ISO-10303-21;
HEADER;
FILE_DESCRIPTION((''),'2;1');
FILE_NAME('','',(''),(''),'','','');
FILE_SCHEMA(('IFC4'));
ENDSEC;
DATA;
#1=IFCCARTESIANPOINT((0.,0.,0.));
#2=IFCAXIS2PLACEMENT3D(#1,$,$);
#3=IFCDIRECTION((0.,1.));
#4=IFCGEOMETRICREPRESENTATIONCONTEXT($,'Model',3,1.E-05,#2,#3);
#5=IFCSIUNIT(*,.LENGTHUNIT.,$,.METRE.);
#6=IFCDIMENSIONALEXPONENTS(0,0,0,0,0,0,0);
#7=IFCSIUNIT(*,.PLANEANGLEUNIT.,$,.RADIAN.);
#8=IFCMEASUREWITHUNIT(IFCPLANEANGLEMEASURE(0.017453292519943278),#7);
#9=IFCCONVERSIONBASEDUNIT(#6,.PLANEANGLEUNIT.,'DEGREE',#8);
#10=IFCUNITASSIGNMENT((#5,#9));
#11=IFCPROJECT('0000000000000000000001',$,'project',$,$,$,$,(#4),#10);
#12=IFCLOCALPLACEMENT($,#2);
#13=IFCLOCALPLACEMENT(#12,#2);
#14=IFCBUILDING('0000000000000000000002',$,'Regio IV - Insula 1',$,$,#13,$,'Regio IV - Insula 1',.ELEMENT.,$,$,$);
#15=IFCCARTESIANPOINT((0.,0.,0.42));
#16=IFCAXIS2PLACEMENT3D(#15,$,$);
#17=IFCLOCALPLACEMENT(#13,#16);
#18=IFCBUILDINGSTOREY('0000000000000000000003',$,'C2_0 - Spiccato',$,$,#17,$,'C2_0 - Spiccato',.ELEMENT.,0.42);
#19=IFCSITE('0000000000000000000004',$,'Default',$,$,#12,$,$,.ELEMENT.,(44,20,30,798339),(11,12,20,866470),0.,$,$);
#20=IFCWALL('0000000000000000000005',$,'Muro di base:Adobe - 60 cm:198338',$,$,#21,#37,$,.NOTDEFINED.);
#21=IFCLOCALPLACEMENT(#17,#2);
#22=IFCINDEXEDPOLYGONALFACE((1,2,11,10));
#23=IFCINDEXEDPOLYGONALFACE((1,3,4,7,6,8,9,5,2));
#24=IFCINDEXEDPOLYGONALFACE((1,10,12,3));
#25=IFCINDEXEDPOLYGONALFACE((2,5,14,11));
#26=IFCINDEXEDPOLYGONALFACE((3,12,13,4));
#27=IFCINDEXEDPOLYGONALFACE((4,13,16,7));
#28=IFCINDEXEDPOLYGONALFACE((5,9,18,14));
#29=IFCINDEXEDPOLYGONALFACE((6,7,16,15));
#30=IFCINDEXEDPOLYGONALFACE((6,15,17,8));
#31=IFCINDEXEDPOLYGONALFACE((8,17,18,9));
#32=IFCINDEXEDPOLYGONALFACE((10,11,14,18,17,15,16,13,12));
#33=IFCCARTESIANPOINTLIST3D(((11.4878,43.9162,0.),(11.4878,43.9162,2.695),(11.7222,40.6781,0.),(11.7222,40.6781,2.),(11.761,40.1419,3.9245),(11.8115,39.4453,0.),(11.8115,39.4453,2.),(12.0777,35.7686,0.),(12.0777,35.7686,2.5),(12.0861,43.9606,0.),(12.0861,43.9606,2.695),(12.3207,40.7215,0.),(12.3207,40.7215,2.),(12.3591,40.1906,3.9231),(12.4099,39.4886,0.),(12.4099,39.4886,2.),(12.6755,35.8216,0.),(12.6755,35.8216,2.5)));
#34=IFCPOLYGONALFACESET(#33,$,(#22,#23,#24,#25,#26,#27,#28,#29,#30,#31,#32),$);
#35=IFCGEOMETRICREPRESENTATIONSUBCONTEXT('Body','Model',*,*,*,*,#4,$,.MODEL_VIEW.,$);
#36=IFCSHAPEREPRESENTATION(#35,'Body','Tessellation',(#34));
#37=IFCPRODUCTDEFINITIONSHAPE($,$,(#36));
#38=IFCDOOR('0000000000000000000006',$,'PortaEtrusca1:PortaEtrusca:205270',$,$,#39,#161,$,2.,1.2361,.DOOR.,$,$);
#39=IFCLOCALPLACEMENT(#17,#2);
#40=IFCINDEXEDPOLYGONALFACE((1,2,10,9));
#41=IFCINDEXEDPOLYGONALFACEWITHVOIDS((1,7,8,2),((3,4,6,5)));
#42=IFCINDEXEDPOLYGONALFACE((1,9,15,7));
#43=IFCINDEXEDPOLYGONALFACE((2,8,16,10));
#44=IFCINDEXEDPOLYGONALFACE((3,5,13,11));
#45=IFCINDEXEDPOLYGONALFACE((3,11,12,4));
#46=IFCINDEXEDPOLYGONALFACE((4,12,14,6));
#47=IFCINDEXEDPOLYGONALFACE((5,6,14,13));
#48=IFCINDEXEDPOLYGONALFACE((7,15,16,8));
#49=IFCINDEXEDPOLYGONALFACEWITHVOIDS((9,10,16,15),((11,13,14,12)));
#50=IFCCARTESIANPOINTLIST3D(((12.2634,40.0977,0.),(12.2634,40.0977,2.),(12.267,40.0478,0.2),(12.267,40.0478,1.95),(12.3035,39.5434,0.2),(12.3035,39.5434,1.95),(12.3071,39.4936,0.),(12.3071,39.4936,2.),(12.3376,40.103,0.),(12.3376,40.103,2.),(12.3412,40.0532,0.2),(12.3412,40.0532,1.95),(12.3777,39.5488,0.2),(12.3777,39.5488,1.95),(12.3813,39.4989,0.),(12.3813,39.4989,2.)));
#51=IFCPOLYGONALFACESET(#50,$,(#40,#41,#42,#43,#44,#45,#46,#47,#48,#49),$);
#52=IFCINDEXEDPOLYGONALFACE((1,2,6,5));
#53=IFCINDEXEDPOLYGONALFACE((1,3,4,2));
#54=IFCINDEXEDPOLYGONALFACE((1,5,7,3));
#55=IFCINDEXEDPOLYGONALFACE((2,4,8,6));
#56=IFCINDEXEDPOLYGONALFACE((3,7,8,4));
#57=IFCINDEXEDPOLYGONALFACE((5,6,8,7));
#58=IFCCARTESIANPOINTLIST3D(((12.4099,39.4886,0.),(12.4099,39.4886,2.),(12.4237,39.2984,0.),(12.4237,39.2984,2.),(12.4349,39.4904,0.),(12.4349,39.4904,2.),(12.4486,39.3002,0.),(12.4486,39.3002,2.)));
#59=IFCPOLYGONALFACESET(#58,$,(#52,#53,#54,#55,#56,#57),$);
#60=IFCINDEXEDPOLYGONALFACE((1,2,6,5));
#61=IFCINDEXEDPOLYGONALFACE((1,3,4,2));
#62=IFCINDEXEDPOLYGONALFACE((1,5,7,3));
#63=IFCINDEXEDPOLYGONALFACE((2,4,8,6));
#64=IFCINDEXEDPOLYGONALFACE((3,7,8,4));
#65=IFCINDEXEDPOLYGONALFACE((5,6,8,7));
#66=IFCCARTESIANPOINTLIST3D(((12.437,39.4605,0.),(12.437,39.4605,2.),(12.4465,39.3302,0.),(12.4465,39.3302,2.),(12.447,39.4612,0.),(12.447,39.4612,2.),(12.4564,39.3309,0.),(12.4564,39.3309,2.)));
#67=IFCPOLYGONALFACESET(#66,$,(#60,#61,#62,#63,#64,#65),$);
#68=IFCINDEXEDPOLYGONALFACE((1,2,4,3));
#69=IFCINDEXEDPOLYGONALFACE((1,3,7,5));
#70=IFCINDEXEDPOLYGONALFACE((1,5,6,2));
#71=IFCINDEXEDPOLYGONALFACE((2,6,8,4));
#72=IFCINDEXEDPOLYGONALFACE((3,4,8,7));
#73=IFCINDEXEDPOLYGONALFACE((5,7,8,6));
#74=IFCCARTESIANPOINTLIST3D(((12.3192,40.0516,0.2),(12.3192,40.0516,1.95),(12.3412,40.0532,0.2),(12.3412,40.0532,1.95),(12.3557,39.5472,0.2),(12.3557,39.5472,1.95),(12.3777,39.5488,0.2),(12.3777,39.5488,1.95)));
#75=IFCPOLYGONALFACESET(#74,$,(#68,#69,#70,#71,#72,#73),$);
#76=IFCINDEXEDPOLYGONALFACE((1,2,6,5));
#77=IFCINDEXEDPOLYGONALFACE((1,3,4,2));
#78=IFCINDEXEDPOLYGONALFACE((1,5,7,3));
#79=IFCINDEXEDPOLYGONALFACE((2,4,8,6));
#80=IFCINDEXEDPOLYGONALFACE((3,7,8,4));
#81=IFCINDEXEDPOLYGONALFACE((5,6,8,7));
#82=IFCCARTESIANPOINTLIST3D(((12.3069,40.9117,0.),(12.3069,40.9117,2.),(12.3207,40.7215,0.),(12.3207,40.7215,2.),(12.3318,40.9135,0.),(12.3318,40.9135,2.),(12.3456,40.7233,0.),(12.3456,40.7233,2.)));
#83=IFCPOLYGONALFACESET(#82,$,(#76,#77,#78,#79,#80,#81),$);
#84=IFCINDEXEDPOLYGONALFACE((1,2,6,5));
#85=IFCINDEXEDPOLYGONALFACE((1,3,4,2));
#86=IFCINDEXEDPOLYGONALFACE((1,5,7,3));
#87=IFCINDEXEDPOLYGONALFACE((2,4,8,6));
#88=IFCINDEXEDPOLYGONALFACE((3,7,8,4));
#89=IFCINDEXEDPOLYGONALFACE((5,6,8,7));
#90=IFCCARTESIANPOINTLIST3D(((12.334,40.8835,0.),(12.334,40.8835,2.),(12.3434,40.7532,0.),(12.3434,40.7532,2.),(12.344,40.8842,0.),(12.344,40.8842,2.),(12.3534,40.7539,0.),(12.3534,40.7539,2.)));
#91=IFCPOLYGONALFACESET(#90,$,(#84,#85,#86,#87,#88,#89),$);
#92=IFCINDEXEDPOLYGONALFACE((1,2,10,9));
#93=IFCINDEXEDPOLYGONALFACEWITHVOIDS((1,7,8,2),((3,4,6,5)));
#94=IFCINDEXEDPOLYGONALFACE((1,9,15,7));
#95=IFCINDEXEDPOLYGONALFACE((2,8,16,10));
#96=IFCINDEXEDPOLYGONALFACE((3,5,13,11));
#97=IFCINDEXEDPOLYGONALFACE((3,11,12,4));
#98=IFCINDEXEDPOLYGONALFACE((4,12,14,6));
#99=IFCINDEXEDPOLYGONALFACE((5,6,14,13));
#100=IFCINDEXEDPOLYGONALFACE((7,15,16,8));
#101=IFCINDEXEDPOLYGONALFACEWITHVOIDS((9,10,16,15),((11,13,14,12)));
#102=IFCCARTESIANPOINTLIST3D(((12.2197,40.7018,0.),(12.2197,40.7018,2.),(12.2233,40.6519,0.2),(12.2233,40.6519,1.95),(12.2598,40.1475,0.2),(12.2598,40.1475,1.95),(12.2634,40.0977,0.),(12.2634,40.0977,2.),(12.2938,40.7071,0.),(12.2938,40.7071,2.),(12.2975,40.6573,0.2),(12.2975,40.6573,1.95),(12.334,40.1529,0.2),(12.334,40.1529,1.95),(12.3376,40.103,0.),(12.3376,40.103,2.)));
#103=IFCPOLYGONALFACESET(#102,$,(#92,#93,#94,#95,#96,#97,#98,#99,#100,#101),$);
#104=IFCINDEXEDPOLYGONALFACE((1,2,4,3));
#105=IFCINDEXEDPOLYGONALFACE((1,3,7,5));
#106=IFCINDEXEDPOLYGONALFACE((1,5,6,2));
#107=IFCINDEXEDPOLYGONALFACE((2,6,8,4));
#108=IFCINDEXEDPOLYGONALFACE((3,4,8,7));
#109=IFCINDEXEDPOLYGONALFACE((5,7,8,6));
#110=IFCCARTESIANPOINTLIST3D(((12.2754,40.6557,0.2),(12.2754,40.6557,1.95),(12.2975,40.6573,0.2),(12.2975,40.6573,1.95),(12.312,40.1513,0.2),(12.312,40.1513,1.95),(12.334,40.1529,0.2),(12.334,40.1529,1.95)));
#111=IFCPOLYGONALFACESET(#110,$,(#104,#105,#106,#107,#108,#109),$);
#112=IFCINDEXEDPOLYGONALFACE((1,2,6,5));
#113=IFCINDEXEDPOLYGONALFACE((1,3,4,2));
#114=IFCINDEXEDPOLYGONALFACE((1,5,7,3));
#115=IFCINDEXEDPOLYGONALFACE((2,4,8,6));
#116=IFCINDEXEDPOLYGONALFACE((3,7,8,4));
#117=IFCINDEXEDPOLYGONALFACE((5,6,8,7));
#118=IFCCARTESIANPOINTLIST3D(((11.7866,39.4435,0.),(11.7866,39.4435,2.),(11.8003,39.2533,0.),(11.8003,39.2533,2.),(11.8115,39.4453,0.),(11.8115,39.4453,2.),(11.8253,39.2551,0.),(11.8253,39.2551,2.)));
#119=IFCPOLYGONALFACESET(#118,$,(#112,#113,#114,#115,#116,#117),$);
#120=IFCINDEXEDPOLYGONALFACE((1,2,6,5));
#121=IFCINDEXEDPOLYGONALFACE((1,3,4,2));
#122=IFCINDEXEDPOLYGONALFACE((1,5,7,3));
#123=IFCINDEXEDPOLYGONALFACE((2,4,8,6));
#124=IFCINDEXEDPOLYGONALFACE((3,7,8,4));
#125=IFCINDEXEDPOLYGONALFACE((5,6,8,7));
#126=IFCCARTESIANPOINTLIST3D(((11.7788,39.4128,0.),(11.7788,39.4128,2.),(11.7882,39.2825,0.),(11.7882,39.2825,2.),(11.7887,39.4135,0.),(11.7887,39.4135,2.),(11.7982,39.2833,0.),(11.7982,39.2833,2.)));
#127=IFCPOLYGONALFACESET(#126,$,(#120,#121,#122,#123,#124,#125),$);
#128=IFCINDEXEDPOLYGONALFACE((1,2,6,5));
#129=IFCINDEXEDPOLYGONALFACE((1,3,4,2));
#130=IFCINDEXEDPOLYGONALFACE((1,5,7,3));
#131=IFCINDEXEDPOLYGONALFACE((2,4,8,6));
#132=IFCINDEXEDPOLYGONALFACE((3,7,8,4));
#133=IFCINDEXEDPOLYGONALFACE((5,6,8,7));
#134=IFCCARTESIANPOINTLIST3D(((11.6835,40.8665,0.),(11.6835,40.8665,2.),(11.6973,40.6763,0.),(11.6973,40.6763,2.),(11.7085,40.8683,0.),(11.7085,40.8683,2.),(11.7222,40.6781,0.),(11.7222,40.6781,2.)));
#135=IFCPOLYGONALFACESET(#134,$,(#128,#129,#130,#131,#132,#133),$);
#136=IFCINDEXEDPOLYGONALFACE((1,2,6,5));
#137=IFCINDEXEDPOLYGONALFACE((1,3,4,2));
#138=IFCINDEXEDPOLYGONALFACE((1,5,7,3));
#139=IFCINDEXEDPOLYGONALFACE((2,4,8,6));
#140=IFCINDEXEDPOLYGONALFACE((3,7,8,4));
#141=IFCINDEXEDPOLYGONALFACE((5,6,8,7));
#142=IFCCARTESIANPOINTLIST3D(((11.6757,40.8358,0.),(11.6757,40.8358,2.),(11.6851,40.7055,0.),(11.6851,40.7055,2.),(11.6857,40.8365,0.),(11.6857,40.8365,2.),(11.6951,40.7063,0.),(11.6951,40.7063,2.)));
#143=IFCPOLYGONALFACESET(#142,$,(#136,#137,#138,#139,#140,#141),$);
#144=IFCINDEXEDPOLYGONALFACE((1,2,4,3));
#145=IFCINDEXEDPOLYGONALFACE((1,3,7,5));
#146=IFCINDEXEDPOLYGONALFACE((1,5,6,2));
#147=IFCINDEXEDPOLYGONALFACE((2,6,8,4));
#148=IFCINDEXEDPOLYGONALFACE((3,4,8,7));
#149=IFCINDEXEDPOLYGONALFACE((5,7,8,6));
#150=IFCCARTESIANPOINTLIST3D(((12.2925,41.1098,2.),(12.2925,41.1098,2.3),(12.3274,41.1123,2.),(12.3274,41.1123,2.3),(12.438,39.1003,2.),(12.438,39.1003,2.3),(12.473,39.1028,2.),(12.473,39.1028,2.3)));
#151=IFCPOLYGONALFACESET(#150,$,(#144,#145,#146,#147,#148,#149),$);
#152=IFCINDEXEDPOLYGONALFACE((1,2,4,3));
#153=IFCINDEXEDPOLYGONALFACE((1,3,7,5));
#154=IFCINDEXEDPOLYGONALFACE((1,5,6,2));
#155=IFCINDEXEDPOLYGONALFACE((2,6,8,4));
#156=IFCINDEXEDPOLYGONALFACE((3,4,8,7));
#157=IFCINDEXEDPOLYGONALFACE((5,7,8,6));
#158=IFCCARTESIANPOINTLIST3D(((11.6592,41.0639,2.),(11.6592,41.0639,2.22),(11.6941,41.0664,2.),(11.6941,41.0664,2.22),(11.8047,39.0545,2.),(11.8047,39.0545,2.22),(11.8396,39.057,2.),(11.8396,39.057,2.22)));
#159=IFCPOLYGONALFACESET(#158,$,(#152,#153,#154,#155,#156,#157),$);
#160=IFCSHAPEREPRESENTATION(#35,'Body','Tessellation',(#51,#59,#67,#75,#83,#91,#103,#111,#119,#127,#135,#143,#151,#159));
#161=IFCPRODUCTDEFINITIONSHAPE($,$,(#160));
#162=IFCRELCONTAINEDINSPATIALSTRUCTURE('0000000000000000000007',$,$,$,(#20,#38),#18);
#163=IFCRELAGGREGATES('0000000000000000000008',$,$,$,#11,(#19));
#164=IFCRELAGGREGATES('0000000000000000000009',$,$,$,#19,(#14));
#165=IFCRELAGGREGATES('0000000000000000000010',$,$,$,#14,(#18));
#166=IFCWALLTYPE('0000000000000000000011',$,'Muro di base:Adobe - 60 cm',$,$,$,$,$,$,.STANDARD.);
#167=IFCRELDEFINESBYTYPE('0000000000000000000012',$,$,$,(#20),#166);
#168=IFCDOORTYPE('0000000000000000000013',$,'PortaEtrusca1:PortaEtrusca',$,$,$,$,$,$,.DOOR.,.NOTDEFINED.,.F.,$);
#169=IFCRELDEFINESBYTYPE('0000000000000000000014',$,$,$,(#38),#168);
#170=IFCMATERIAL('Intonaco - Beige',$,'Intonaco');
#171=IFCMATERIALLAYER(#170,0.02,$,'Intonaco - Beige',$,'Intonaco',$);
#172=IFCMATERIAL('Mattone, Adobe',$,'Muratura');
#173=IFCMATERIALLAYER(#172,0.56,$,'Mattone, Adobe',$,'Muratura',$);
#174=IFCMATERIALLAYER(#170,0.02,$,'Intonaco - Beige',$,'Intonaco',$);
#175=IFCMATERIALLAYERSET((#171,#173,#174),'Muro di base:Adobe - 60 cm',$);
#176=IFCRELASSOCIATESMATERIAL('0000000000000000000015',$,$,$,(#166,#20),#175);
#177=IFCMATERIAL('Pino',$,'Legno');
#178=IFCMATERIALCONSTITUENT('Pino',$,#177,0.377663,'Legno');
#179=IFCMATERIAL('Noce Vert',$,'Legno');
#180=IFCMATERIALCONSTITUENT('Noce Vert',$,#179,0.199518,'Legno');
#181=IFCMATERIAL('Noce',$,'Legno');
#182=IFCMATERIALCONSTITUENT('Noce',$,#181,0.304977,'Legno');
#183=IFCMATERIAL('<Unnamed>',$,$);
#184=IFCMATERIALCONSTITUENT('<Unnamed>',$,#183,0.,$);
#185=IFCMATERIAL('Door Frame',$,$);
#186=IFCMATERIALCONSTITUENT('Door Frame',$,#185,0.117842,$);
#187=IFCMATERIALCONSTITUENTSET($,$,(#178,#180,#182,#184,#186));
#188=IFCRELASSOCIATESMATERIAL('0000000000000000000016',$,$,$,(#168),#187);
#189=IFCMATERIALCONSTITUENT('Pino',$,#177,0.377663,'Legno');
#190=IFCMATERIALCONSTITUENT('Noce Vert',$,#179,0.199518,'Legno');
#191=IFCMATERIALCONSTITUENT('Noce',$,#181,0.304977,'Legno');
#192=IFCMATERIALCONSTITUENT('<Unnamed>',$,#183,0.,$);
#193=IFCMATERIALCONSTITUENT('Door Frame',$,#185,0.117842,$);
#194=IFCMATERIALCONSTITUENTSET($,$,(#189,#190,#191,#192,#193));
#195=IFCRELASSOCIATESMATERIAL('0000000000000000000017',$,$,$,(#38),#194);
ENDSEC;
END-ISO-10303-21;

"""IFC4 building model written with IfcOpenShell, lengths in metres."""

from ifc_helpers import new_model, entity, si_unit, converted_unit, direction, frame, frame_2d, origin, origin_2d_with_axis, place, context, subcontext, project, spatial, polyline, rectangle, outline, extrude, clip, bounded_halfspace, source, transform, mapped, material, layer, layer_set, layer_usage, constituent, constituent_set, type_object, type_shapes, element, fill, save


model = new_model("IFC4")

# Units and contexts
model_context = context("Model", 3, precision=1e-05, world=origin(), true_north=direction((0.0, 1.0)))
body_context = subcontext(model_context, "Body", "Model", "MODEL_VIEW")
ifc_project = project(units=[si_unit("LENGTHUNIT", "METRE"), converted_unit("PLANEANGLEUNIT", "DEGREE", entity("IfcPlaneAngleMeasure", 0.017453292519943278), si_unit("PLANEANGLEUNIT", "RADIAN"), dimensions=[0, 0, 0, 0, 0, 0, 0])], contexts=[model_context])

# Site, building, storey
site_placement = place(None, origin())
site = spatial("IfcSite", under=ifc_project, at=site_placement, Name="Default", CompositionType="ELEMENT", RefLatitude=(44, 20, 30, 798339), RefLongitude=(11, 12, 20, 866470), RefElevation=0.0)
building_placement = place(site_placement, origin())
building = spatial("IfcBuilding", under=site, at=building_placement, Name="Regio IV - Insula 1", LongName="Regio IV - Insula 1", CompositionType="ELEMENT")
storey_placement = place(building_placement, frame((0.0, 0.0, 0.42)))
storey = spatial("IfcBuildingStorey", under=building, at=storey_placement, Name="C2_0 - Spiccato", LongName="C2_0 - Spiccato", CompositionType="ELEMENT", Elevation=0.42)

# Shared definitions
ifc_material_1 = material(Name="Intonaco - Beige", Category="Intonaco")
ifc_layer_1 = layer(ifc_material_1, 0.02, Name="Intonaco - Beige", Category="Intonaco")
ifc_material_2 = material(Name="Mattone, Adobe", Category="Muratura")
ifc_layer_2 = layer(ifc_material_2, 0.56, Name="Mattone, Adobe", Category="Muratura")
ifc_layer_3 = layer(ifc_material_1, 0.02, Name="Intonaco - Beige", Category="Intonaco")
ifc_layer_set = layer_set([ifc_layer_1, ifc_layer_2, ifc_layer_3], Name="Muro di base:Adobe - 60 cm")
wall_type = type_object("IfcWallType", Name="Muro di base:Adobe - 60 cm", PredefinedType="STANDARD", material=ifc_layer_set)
ifc_material_3 = material(Name="Pino", Category="Legno")
ifc_material_4 = material(Name="Noce Vert", Category="Legno")
ifc_material_5 = material(Name="Noce", Category="Legno")
ifc_material_6 = material(Name="<Unnamed>")
ifc_material_7 = material(Name="Door Frame")
ifc_constituent_1 = constituent(ifc_material_3, Name="Pino", Category="Legno", fraction=0.377663)
ifc_constituent_2 = constituent(ifc_material_4, Name="Noce Vert", Category="Legno", fraction=0.199518)
ifc_constituent_3 = constituent(ifc_material_5, Name="Noce", Category="Legno", fraction=0.304977)
ifc_constituent_4 = constituent(ifc_material_6, Name="<Unnamed>", fraction=0.0)
ifc_constituent_5 = constituent(ifc_material_7, Name="Door Frame", fraction=0.117842)
ifc_constituent_set_1 = constituent_set(constituents=[ifc_constituent_1, ifc_constituent_2, ifc_constituent_3, ifc_constituent_4, ifc_constituent_5])
door_type = type_object("IfcDoorType", Name="PortaEtrusca1:PortaEtrusca", OperationType="NOTDEFINED", ParameterTakesPrecedence=False, PredefinedType="DOOR", material=ifc_constituent_set_1)
shared_shape = source(origin(), body_context, "Body", "SweptSolid", [
    extrude(outline(polyline([(-1.0, -0.3028), (1.0, -0.3028), (1.0, 0.3028), (-1.0, 0.3028), (-1.0, -0.3028)]), holes=[polyline([(-0.95, 0.2528), (0.8, 0.2528), (0.8, -0.2528), (-0.95, -0.2528), (-0.95, 0.2528)])]), frame((0.3152, 0.0278, 1.0), z_axis=(0.0, 1.0, 0.0), x_axis=(0.0, 0.0, -1.0)), (0.0, 0.0, 1.0), 0.0744),
    extrude(rectangle(XDim=0.025, YDim=0.1907, at=frame_2d((0.0, 0.0), x_axis=(1.0, 0.0))), frame((-0.0953, -0.0125, 0.0), z_axis=(0.0, 0.0, 1.0), x_axis=(0.0, 1.0, 0.0)), (0.0, 0.0, 1.0), 2.0),
    extrude(rectangle(XDim=0.01, YDim=0.1306, at=frame_2d((0.0, 0.0), x_axis=(1.0, 0.0))), frame((-0.0953, -0.03, 0.0), z_axis=(0.0, 0.0, 1.0), x_axis=(0.0, 1.0, 0.0)), (0.0, 0.0, 1.0), 2.0),
    extrude(rectangle(XDim=0.0221, YDim=0.5057, at=frame_2d((0.0, 0.0), x_axis=(1.0, 0.0))), frame((0.3152, 0.0388, 0.2), z_axis=(0.0, 0.0, 1.0), x_axis=(0.0, 1.0, 0.0)), (0.0, 0.0, 1.0), 1.75),
    extrude(rectangle(XDim=0.025, YDim=0.1907, at=frame_2d((0.0, 0.0), x_axis=(1.0, 0.0))), frame((1.3314, -0.0125, 0.0), z_axis=(0.0, 0.0, 1.0), x_axis=(0.0, 1.0, 0.0)), (0.0, 0.0, 1.0), 2.0),
    extrude(rectangle(XDim=0.01, YDim=0.1306, at=frame_2d((0.0, 0.0), x_axis=(1.0, 0.0))), frame((1.3314, -0.03, 0.0), z_axis=(0.0, 0.0, 1.0), x_axis=(0.0, 1.0, 0.0)), (0.0, 0.0, 1.0), 2.0),
    extrude(outline(polyline([(-0.3028, -1.0), (0.3028, -1.0), (0.3028, 1.0), (-0.3028, 1.0), (-0.3028, -1.0)]), holes=[polyline([(0.2528, -0.95), (-0.2528, -0.95), (-0.2528, 0.8), (0.2528, 0.8), (0.2528, -0.95)])]), frame((0.9209, 0.0278, 1.0), z_axis=(0.0, 1.0, 0.0), x_axis=(1.0, 0.0, 0.0)), (0.0, 0.0, 1.0), 0.0744),
    extrude(rectangle(XDim=0.0221, YDim=0.5057, at=frame_2d((0.0, 0.0), x_axis=(1.0, 0.0))), frame((0.9209, 0.0388, 0.2), z_axis=(0.0, 0.0, 1.0), x_axis=(0.0, 1.0, 0.0)), (0.0, 0.0, 1.0), 1.75),
    extrude(rectangle(XDim=0.025, YDim=0.1907, at=frame_2d((0.0, 0.0), x_axis=(1.0, 0.0))), frame((-0.0953, 0.6125, 0.0), z_axis=(0.0, 0.0, 1.0), x_axis=(0.0, -1.0, 0.0)), (0.0, 0.0, 1.0), 2.0),
    extrude(rectangle(XDim=0.01, YDim=0.1306, at=origin_2d_with_axis()), frame((-0.0953, 0.63, 0.0), z_axis=(0.0, 0.0, 1.0), x_axis=(0.0, -1.0, 0.0)), (0.0, 0.0, 1.0), 2.0),
    extrude(rectangle(XDim=0.025, YDim=0.1907, at=frame_2d((0.0, 0.0), x_axis=(1.0, 0.0))), frame((1.3314, 0.6125, 0.0), z_axis=(0.0, 0.0, 1.0), x_axis=(0.0, -1.0, 0.0)), (0.0, 0.0, 1.0), 2.0),
    extrude(rectangle(XDim=0.01, YDim=0.1306, at=origin_2d_with_axis()), frame((1.3314, 0.63, 0.0), z_axis=(0.0, 0.0, 1.0), x_axis=(0.0, -1.0, 0.0)), (0.0, 0.0, 1.0), 2.0),
    extrude(rectangle(XDim=0.035, YDim=2.0147, at=frame_2d((0.0, 0.0), x_axis=(1.0, 0.0))), frame((0.618, -0.0175, 2.0), z_axis=(0.0, 0.0, 1.0), x_axis=(0.0, 1.0, 0.0)), (0.0, 0.0, 1.0), 0.3),
    extrude(rectangle(XDim=0.035, YDim=2.0147, at=frame_2d((0.0, 0.0), x_axis=(1.0, 0.0))), frame((0.618, 0.6175, 2.0), z_axis=(0.0, 0.0, 1.0), x_axis=(0.0, -1.0, 0.0)), (0.0, 0.0, 1.0), 0.22),
])
type_shapes(door_type, [shared_shape])

# Wall, opening, door
ifc_layer_usage_1 = layer_usage(ifc_layer_set, "AXIS2", "NEGATIVE", 0.3)
wall_1_placement = place(storey_placement, frame((12.3769, 35.7903, 0.0), z_axis=(0.0, 0.0, 1.0), x_axis=(-0.07222, 0.997389, 0.0)))
wall_1 = element("IfcWall", 1, at=wall_1_placement, inside=storey, type_object=wall_type, material=ifc_layer_usage_1, Name="Muro di base:Adobe - 60 cm:198338", PredefinedType="NOTDEFINED", context=body_context, shape_type="Clipping", body=[
    clip(clip(extrude(outline(polyline([(0.0096, -0.3), (8.1699, -0.3), (8.1689, 0.3), (0.0, 0.3), (0.0096, -0.3)])), origin(), (0.0, 0.0, 1.0), 3.9245), bounded_halfspace(frame((8.1699, -0.3, 2.695), z_axis=(0.309017, 0.000507, 0.951057), x_axis=(-0.001641, 0.999999, 0.0)), False, frame((8.1699, -0.3, 2.695)), polyline([(0.0, 0.0), (-0.001, 0.6), (-3.7852, 0.6), (-3.7799, 0.0), (0.0, 0.0)]))), bounded_halfspace(frame((0.0, 0.3, 2.5), z_axis=(-0.308977, -0.004962, 0.951057), x_axis=(0.016056, -0.999871, 0.0)), False, frame((0.0, 0.3, 2.5)), polyline([(0.0, 0.0), (0.0096, -0.6), (4.3901, -0.6), (4.3848, 0.0), (0.6001, 0.0), (0.0, 0.0)]))),
])
opening_1_placement = place(wall_1_placement, frame((3.6863, -0.3, 0.0)))
opening_1 = element("IfcOpeningElement", 2, at=opening_1_placement, cuts=wall_1, PredefinedType="OPENING", context=body_context, shape_type="SweptSolid", body=[
    extrude(rectangle(XDim=2.0, YDim=1.2361, at=frame_2d((1.0, 0.618), x_axis=(1.0, 0.0))), frame((0.0, 0.0, 0.0), z_axis=(0.0, 1.0, 0.0), x_axis=(0.0, 0.0, 1.0)), (0.0, 0.0, 1.0), 0.6),
])
ifc_constituent_6 = constituent(ifc_material_3, Name="Pino", Category="Legno", fraction=0.377663)
ifc_constituent_7 = constituent(ifc_material_4, Name="Noce Vert", Category="Legno", fraction=0.199518)
ifc_constituent_8 = constituent(ifc_material_5, Name="Noce", Category="Legno", fraction=0.304977)
ifc_constituent_9 = constituent(ifc_material_6, Name="<Unnamed>", fraction=0.0)
ifc_constituent_10 = constituent(ifc_material_7, Name="Door Frame", fraction=0.117842)
ifc_constituent_set_2 = constituent_set(constituents=[ifc_constituent_6, ifc_constituent_7, ifc_constituent_8, ifc_constituent_9, ifc_constituent_10])
door_1_placement = place(opening_1_placement, origin())
door_1 = element("IfcDoor", 3, at=door_1_placement, inside=storey, type_object=door_type, material=ifc_constituent_set_2, Name="PortaEtrusca1:PortaEtrusca:205270", OverallHeight=2.0, OverallWidth=1.2361, PredefinedType="DOOR", context=body_context, shape_type="MappedRepresentation", body=[
    mapped(shared_shape, transform((0.0, 0.0, 0.0), scale=1.0)),
])
fill(opening_1, door_1)

save(model, "model.ifc")
